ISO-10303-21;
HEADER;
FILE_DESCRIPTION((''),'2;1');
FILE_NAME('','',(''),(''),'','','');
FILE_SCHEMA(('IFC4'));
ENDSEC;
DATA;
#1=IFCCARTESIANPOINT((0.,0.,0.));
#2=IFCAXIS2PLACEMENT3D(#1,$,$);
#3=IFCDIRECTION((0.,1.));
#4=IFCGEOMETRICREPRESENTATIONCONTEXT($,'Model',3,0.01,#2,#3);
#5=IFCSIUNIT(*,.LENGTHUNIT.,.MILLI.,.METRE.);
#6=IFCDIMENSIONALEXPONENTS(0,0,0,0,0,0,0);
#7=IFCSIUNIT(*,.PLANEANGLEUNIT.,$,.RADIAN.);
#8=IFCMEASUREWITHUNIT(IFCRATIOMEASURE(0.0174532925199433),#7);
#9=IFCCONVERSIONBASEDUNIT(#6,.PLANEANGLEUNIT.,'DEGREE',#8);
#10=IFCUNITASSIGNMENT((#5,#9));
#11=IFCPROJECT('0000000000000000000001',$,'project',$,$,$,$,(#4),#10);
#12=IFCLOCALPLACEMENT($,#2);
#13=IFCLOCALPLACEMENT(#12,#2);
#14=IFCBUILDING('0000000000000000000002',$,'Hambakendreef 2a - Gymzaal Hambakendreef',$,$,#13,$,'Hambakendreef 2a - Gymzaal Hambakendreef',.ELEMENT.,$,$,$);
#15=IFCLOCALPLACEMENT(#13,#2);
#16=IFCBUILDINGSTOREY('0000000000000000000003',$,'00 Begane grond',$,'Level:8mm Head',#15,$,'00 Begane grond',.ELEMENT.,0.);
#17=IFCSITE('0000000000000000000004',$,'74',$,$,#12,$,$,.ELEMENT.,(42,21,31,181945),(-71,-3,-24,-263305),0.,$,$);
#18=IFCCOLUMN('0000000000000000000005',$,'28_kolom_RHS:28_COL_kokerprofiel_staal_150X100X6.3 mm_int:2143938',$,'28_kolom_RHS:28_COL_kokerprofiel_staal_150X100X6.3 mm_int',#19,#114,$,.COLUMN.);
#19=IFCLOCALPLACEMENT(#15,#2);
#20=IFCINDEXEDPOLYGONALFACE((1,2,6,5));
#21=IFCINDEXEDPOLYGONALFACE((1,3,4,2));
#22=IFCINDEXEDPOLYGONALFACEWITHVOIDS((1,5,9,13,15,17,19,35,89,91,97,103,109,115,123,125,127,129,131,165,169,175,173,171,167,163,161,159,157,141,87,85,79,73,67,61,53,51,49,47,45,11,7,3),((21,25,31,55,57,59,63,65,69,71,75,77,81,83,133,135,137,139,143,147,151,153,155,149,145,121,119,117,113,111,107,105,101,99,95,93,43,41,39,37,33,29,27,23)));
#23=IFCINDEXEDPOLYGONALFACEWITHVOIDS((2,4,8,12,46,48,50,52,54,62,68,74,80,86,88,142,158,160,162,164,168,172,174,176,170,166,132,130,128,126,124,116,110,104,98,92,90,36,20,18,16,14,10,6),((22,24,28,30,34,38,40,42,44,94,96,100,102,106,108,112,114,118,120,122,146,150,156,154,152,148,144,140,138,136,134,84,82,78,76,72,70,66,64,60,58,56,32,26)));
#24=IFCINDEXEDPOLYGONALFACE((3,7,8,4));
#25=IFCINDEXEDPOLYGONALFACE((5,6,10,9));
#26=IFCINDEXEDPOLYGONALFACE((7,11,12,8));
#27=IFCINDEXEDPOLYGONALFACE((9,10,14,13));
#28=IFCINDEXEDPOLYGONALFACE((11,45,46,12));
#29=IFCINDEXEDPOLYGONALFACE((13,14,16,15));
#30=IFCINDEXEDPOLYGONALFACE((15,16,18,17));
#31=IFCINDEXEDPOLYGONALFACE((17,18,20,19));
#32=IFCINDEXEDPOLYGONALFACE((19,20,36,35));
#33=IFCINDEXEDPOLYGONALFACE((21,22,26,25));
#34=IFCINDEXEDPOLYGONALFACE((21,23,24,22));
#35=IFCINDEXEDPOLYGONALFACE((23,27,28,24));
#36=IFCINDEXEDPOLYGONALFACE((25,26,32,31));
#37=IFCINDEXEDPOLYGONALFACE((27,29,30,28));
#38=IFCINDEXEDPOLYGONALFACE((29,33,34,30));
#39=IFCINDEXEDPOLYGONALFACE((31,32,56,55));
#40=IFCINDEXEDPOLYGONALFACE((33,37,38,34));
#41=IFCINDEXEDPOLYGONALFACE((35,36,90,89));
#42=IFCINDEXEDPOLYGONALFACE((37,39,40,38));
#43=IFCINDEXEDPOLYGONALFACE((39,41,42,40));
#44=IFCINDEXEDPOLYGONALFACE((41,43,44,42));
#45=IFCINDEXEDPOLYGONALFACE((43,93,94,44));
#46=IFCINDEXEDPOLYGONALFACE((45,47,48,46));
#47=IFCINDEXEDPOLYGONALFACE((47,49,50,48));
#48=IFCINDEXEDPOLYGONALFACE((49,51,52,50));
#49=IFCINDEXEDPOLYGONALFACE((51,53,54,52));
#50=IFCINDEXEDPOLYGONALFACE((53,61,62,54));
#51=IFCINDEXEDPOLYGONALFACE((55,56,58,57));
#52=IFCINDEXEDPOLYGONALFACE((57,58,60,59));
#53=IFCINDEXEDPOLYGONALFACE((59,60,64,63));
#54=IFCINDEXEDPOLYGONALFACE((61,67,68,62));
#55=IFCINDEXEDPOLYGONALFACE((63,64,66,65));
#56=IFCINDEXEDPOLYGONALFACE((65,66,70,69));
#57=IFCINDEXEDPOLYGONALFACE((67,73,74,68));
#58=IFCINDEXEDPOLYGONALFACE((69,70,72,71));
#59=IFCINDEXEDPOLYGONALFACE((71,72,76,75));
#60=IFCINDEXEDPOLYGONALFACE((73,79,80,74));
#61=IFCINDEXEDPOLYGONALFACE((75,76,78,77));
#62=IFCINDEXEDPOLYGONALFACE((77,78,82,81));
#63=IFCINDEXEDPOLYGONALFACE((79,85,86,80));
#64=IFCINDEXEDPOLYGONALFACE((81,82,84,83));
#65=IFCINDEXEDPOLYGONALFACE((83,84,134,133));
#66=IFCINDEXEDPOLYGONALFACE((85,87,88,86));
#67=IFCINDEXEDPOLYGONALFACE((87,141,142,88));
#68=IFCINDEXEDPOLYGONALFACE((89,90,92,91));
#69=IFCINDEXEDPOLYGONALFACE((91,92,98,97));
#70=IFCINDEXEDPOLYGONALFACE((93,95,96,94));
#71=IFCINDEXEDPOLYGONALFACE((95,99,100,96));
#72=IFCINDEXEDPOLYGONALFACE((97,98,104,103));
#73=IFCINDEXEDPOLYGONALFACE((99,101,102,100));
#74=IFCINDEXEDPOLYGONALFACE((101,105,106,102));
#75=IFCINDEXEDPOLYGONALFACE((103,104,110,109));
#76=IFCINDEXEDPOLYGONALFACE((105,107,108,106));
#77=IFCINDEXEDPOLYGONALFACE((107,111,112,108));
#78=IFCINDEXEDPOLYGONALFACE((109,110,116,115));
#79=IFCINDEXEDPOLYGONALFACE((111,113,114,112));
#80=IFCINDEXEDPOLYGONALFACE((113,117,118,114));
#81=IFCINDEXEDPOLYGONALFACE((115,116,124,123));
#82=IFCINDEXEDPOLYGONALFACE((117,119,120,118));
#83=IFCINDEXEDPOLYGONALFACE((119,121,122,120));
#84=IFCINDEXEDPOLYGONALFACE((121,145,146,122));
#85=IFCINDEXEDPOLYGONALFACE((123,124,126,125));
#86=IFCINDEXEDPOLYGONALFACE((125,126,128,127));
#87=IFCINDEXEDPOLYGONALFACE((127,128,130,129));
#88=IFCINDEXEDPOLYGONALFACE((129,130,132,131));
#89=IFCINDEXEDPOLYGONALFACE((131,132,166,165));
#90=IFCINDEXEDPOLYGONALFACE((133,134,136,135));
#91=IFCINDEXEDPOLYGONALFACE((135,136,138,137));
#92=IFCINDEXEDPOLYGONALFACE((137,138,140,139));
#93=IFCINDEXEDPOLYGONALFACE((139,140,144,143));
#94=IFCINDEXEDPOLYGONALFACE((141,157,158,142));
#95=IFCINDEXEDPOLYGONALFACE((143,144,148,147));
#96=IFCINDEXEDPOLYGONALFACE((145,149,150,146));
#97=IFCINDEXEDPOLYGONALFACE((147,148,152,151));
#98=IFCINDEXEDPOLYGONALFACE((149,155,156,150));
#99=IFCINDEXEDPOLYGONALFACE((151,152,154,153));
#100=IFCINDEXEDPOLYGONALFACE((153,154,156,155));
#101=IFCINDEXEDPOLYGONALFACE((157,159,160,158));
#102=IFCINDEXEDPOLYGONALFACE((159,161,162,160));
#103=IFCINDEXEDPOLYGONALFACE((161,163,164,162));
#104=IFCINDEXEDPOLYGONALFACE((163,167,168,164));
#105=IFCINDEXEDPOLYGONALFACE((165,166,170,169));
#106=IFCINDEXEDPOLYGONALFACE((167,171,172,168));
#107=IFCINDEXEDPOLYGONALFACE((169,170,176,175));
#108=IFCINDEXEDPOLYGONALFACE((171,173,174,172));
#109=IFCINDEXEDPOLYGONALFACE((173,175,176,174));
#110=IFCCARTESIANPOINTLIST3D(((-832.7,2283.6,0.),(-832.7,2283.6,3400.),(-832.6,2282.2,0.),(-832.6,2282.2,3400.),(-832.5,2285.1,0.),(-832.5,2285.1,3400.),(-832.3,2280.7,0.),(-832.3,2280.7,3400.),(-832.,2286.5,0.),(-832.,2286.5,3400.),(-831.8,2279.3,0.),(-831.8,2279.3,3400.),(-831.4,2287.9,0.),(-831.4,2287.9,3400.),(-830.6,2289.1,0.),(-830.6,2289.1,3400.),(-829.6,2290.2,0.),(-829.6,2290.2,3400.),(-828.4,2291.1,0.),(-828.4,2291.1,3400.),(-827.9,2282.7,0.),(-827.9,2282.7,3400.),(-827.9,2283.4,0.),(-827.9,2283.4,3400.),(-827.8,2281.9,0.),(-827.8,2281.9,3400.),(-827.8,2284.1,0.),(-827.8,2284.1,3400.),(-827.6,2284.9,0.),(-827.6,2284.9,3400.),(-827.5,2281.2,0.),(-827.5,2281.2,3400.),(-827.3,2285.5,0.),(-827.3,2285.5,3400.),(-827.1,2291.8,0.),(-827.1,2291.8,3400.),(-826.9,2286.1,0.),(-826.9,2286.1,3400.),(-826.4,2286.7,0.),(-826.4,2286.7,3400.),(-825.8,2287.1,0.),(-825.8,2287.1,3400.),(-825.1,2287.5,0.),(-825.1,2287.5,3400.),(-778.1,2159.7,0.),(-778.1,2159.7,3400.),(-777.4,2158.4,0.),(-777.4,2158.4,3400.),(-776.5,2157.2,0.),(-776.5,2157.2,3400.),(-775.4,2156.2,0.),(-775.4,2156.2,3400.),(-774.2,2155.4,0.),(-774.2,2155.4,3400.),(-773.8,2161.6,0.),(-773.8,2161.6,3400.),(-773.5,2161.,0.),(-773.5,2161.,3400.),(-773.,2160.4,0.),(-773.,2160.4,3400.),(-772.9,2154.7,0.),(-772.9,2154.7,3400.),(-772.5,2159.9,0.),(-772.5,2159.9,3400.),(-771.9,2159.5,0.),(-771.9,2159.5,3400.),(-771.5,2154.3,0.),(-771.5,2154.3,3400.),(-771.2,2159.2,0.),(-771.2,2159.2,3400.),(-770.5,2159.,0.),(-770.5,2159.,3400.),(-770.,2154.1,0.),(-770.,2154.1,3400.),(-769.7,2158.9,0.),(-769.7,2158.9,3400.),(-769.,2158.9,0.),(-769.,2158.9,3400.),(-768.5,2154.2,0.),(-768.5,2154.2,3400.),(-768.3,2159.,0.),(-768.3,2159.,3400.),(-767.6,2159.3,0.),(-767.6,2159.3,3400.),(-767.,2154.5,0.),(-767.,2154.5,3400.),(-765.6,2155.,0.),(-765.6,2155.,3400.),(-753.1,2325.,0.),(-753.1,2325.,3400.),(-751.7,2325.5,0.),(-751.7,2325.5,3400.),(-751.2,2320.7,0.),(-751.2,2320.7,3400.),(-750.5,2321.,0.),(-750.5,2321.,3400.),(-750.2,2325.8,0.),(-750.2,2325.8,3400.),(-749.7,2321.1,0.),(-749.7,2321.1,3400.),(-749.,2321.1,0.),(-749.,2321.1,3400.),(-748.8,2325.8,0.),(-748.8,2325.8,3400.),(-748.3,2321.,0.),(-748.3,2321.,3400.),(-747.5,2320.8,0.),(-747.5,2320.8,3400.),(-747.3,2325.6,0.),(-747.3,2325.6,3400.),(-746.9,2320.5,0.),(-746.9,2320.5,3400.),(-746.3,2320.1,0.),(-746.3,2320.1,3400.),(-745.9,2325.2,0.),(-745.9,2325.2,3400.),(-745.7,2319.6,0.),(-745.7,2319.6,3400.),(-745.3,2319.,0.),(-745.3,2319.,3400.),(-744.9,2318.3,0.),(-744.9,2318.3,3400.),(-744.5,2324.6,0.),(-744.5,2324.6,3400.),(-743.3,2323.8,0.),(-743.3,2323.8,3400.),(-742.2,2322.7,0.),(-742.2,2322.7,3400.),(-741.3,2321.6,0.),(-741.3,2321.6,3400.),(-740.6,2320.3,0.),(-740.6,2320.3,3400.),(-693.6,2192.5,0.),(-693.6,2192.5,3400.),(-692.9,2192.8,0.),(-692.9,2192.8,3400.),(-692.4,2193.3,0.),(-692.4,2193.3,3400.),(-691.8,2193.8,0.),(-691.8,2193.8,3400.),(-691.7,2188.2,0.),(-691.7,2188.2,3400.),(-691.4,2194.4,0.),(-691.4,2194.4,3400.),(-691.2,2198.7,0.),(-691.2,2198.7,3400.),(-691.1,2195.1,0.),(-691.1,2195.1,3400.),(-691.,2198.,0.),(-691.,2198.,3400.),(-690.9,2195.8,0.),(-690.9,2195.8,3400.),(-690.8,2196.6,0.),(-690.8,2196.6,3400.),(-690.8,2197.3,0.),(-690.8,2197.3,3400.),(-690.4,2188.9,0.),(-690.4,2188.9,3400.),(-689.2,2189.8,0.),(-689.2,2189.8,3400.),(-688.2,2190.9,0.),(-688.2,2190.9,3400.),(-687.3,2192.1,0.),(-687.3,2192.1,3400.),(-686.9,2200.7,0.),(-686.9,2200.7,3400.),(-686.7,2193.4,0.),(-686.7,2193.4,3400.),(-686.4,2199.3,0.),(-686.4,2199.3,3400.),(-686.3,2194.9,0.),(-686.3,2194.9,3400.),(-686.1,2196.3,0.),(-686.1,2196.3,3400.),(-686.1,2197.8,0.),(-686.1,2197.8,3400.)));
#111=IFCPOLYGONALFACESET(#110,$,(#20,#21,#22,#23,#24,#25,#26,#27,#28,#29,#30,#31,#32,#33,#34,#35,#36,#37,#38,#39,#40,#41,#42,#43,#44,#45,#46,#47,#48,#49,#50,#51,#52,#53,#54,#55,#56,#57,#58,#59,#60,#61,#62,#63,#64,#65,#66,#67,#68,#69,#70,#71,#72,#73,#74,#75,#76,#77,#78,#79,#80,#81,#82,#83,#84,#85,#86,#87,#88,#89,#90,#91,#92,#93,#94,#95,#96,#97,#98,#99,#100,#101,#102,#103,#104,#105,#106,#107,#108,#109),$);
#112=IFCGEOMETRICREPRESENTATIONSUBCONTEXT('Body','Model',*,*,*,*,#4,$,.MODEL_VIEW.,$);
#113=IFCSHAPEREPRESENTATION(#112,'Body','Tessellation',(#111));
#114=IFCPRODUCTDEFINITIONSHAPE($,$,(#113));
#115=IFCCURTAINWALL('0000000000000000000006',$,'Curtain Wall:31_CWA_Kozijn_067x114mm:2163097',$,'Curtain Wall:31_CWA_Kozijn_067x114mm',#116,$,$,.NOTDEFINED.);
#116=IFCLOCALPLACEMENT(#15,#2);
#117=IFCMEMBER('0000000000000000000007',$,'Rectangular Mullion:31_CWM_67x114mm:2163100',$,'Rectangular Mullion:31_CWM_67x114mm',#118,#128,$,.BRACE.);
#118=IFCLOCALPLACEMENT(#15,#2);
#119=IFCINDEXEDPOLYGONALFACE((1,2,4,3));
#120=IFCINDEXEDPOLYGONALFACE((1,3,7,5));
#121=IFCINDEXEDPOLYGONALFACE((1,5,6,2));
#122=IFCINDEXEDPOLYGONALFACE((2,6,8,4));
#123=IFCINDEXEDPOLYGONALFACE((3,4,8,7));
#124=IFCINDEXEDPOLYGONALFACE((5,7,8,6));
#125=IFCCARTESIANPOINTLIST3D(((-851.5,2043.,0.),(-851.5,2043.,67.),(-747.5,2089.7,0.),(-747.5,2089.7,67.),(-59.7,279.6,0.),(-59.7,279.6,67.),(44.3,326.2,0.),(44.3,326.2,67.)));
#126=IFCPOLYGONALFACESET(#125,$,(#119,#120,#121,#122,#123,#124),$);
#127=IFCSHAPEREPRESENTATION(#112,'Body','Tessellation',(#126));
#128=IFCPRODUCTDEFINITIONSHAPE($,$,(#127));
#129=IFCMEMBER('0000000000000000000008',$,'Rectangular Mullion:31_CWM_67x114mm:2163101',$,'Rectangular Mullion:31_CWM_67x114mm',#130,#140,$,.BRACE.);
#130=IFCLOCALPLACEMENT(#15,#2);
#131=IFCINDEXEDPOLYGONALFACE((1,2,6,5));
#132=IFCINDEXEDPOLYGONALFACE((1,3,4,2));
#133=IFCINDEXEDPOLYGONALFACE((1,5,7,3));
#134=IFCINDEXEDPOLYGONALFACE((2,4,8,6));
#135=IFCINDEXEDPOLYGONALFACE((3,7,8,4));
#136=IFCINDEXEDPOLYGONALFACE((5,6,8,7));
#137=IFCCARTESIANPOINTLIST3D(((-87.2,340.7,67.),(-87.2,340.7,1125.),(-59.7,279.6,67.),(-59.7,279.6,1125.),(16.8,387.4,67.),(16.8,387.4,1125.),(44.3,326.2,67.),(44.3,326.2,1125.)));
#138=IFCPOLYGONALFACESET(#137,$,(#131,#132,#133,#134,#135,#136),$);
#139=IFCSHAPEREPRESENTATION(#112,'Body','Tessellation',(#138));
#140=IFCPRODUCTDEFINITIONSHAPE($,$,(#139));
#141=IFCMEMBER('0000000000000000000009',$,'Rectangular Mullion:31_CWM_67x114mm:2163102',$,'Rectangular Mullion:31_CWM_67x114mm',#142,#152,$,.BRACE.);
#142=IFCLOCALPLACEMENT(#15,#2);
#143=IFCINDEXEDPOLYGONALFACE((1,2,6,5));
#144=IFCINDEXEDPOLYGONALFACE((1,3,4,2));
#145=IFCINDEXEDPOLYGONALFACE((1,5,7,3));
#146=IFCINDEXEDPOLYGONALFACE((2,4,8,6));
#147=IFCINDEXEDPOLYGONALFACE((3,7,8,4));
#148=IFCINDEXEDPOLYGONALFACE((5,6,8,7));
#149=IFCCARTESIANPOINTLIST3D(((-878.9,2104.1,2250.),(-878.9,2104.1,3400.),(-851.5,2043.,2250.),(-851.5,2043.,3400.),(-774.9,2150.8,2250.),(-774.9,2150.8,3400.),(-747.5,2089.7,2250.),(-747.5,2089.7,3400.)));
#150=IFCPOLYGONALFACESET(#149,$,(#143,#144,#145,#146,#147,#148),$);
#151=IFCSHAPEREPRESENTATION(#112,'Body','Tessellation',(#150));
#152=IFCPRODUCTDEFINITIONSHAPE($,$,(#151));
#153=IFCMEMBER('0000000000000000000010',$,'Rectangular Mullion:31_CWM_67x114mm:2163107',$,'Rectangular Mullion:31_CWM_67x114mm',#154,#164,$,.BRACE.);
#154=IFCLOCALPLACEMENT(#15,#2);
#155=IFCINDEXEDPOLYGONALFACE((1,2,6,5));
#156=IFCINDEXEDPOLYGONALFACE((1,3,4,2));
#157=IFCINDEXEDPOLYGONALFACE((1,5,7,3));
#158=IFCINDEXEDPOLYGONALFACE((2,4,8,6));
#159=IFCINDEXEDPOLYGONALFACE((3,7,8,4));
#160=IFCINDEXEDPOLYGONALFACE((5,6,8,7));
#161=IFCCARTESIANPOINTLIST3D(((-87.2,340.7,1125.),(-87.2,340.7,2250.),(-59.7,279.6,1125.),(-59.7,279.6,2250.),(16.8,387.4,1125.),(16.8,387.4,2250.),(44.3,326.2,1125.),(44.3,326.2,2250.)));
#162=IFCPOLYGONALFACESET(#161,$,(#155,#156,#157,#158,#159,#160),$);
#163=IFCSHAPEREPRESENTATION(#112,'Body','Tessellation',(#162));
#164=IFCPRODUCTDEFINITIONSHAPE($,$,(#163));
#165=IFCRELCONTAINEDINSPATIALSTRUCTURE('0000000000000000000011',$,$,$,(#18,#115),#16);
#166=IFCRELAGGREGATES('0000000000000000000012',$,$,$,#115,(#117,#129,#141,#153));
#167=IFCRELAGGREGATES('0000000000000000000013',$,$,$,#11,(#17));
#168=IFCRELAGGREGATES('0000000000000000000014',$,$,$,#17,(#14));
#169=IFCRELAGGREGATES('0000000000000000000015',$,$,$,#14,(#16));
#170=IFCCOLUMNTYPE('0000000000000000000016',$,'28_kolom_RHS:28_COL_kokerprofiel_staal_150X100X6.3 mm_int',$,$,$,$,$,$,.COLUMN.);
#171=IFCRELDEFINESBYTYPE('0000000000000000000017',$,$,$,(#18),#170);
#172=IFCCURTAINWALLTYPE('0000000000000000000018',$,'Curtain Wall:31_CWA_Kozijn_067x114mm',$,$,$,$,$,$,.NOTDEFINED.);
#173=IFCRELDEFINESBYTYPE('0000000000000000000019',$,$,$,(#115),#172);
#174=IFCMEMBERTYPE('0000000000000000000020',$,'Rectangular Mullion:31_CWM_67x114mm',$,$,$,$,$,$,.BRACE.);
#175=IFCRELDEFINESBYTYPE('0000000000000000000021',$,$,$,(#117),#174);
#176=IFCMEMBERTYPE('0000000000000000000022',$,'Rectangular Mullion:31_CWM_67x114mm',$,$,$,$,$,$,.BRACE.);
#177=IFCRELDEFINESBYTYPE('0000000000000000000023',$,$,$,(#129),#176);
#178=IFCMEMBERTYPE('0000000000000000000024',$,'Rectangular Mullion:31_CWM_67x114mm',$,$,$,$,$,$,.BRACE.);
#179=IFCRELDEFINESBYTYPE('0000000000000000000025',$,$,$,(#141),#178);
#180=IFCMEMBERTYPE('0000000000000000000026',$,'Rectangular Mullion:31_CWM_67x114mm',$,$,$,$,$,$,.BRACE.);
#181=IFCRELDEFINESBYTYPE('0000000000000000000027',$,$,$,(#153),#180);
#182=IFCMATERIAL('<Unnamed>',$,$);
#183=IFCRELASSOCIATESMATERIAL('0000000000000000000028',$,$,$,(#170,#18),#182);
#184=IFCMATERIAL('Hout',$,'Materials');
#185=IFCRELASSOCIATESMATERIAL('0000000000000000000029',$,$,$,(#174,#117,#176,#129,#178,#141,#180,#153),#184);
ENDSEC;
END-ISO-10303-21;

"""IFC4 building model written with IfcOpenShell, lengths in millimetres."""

from ifc_helpers import new_model, entity, si_unit, converted_unit, direction, frame, origin, place, context, subcontext, project, spatial, indexed_curve, outline, extrude, source, transform, mapped, material, type_object, type_shapes, element, aggregate, save


model = new_model("IFC4")

# Units and contexts
model_context = context("Model", 3, precision=0.01, world=origin(), true_north=direction((0.0, 1.0)))
body_context = subcontext(model_context, "Body", "Model", "MODEL_VIEW")
ifc_project = project(units=[si_unit("LENGTHUNIT", "METRE", prefix="MILLI"), converted_unit("PLANEANGLEUNIT", "DEGREE", entity("IfcRatioMeasure", 0.0174532925199433), si_unit("PLANEANGLEUNIT", "RADIAN"), dimensions=[0, 0, 0, 0, 0, 0, 0])], contexts=[model_context])

# Site, building, storey
site_placement = place(None, origin())
site = spatial("IfcSite", under=ifc_project, at=site_placement, Name="74", CompositionType="ELEMENT", RefLatitude=(42, 21, 31, 181945), RefLongitude=(-71, -3, -24, -263305), RefElevation=0.0)
building_placement = place(site_placement, origin())
building = spatial("IfcBuilding", under=site, at=building_placement, Name="Hambakendreef 2a - Gymzaal Hambakendreef", LongName="Hambakendreef 2a - Gymzaal Hambakendreef", CompositionType="ELEMENT")
storey_placement = place(building_placement, origin())
storey = spatial("IfcBuildingStorey", under=building, at=storey_placement, Name="00 Begane grond", ObjectType="Level:8mm Head", LongName="00 Begane grond", CompositionType="ELEMENT", Elevation=0.0)

# Column
ifc_material_1 = material(Name="<Unnamed>")
column_type = type_object("IfcColumnType", Name="28_kolom_RHS:28_COL_kokerprofiel_staal_150X100X6.3 mm_int", PredefinedType="COLUMN", material=ifc_material_1)
shared_shape_1 = source(origin(), body_context, "Body", "SweptSolid", [
    extrude(outline(indexed_curve([(-40.5, -75.0), (40.5, -75.0), (42.0, -74.9), (43.5, -74.5), (44.8, -74.0), (46.1, -73.2), (47.2, -72.2), (48.2, -71.1), (49.0, -69.8), (49.5, -68.5), (49.9, -67.0), (50.0, -65.6), (50.0, 65.6), (49.9, 67.0), (49.5, 68.5), (49.0, 69.8), (48.2, 71.1), (47.2, 72.2), (46.1, 73.2), (44.8, 74.0), (43.5, 74.5), (42.0, 74.9), (40.5, 75.0), (-40.5, 75.0), (-42.0, 74.9), (-43.5, 74.5), (-44.8, 74.0), (-46.1, 73.2), (-47.2, 72.2), (-48.2, 71.1), (-49.0, 69.8), (-49.5, 68.5), (-49.9, 67.0), (-50.0, 65.6), (-50.0, -65.6), (-49.9, -67.0), (-49.5, -68.5), (-49.0, -69.8), (-48.2, -71.1), (-47.2, -72.2), (-46.1, -73.2), (-44.8, -74.0), (-43.5, -74.5), (-42.0, -74.9), (-40.5, -75.0)], self_intersect=False), holes=[indexed_curve([(-45.3, 65.5), (-45.2, 66.3), (-45.0, 67.0), (-44.8, 67.7), (-44.4, 68.3), (-43.9, 68.9), (-43.3, 69.4), (-42.7, 69.8), (-42.0, 70.0), (-41.3, 70.2), (-40.6, 70.3), (40.5, 70.3), (41.3, 70.2), (42.0, 70.0), (42.7, 69.8), (43.3, 69.4), (43.9, 68.9), (44.4, 68.3), (44.8, 67.7), (45.0, 67.0), (45.2, 66.3), (45.3, 65.5), (45.3, -65.5), (45.2, -66.3), (45.0, -67.0), (44.8, -67.7), (44.4, -68.3), (43.9, -68.9), (43.3, -69.4), (42.7, -69.8), (42.0, -70.0), (41.3, -70.2), (40.5, -70.3), (-40.6, -70.3), (-41.3, -70.2), (-42.0, -70.0), (-42.7, -69.8), (-43.3, -69.4), (-43.9, -68.9), (-44.4, -68.3), (-44.8, -67.7), (-45.0, -67.0), (-45.2, -66.3), (-45.3, -65.5), (-45.3, 65.5)], self_intersect=False)]), frame((235.6, 34.3, 0.0), z_axis=(0.0, 0.0, 1.0), x_axis=(0.0, 1.0, 0.0)), (0.0, 0.0, 1.0), 3400.0),
])
type_shapes(column_type, [shared_shape_1])
for number, where, z_axis, x_axis, name in (
    (1, (-887.1, 2440.9, 0.0), (0.0, 0.0, 1.0), (0.40959, -0.91227, 0.0), "28_kolom_RHS:28_COL_kokerprofiel_staal_150X100X6.3 mm_int:2143938"),
):
    element("IfcColumn", number, at=place(storey_placement, frame(where, z_axis=z_axis, x_axis=x_axis)), inside=storey, type_object=column_type, material=ifc_material_1, Name=name, ObjectType="28_kolom_RHS:28_COL_kokerprofiel_staal_150X100X6.3 mm_int", PredefinedType="COLUMN", context=body_context, shape_type="MappedRepresentation", body=[
        mapped(shared_shape_1, transform((0.0, 0.0, 0.0), scale=1.0)),
    ])

# Curtain wall, members
curtain_wall_type = type_object("IfcCurtainWallType", Name="Curtain Wall:31_CWA_Kozijn_067x114mm", PredefinedType="NOTDEFINED")
curtain_wall_placement = place(storey_placement, origin())
curtain_wall = element("IfcCurtainWall", 2, at=curtain_wall_placement, inside=storey, type_object=curtain_wall_type, Name="Curtain Wall:31_CWA_Kozijn_067x114mm:2163097", ObjectType="Curtain Wall:31_CWA_Kozijn_067x114mm", PredefinedType="NOTDEFINED")
ifc_material_2 = material(Name="Hout", Category="Materials")
member_type_1 = type_object("IfcMemberType", Name="Rectangular Mullion:31_CWM_67x114mm", PredefinedType="BRACE", material=ifc_material_2)
shared_shape_2 = source(origin(), body_context, "Body", "SweptSolid", [
    extrude(outline(indexed_curve([(-57.0, -33.5), (57.0, -33.5), (57.0, 33.5), (-57.0, 33.5), (-57.0, -33.5)], self_intersect=False)), frame((-33.5, 0.0, -1933.0), z_axis=(0.0, 0.0, 1.0), x_axis=(0.0, -1.0, 0.0)), (0.0, 0.0, 1.0), 1933.0),
])
type_shapes(member_type_1, [shared_shape_2])
member_1_placement = place(storey_placement, frame((-799.5, 2066.3, 0.0), z_axis=(-0.40959, 0.91227, 0.0), x_axis=(0.0, 0.0, -1.0)))
member_1 = element("IfcMember", 3, at=member_1_placement, type_object=member_type_1, material=ifc_material_2, Name="Rectangular Mullion:31_CWM_67x114mm:2163100", ObjectType="Rectangular Mullion:31_CWM_67x114mm", PredefinedType="BRACE", context=body_context, shape_type="MappedRepresentation", body=[
    mapped(shared_shape_2, transform((0.0, 0.0, 0.0), scale=1.0)),
])
member_type_2 = type_object("IfcMemberType", Name="Rectangular Mullion:31_CWM_67x114mm", PredefinedType="BRACE", material=ifc_material_2)
shared_shape_3 = source(origin(), body_context, "Body", "SweptSolid", [
    extrude(outline(indexed_curve([(-57.0, -33.5), (57.0, -33.5), (57.0, 33.5), (-57.0, 33.5), (-57.0, -33.5)], self_intersect=False)), frame((-33.5, 0.0, -1058.0), z_axis=(0.0, 0.0, 1.0), x_axis=(0.0, -1.0, 0.0)), (0.0, 0.0, 1.0), 1058.0),
])
type_shapes(member_type_2, [shared_shape_3])
member_2_placement = place(storey_placement, frame((-7.7, 302.9, 67.0), z_axis=(0.0, 0.0, -1.0), x_axis=(0.40959, -0.91227, 0.0)))
member_2 = element("IfcMember", 4, at=member_2_placement, type_object=member_type_2, material=ifc_material_2, Name="Rectangular Mullion:31_CWM_67x114mm:2163101", ObjectType="Rectangular Mullion:31_CWM_67x114mm", PredefinedType="BRACE", context=body_context, shape_type="MappedRepresentation", body=[
    mapped(shared_shape_3, transform((0.0, 0.0, 0.0), scale=1.0)),
])
member_type_3 = type_object("IfcMemberType", Name="Rectangular Mullion:31_CWM_67x114mm", PredefinedType="BRACE", material=ifc_material_2)
shared_shape_4 = source(origin(), body_context, "Body", "SweptSolid", [
    extrude(outline(indexed_curve([(-57.0, -33.5), (57.0, -33.5), (57.0, 33.5), (-57.0, 33.5), (-57.0, -33.5)], self_intersect=False)), frame((-33.5, 0.0, -1150.0), z_axis=(0.0, 0.0, 1.0), x_axis=(0.0, -1.0, 0.0)), (0.0, 0.0, 1.0), 1150.0),
])
type_shapes(member_type_3, [shared_shape_4])
member_3_placement = place(storey_placement, frame((-826.9, 2127.4, 3400.0), z_axis=(0.0, 0.0, 1.0), x_axis=(-0.40959, 0.91227, 0.0)))
member_3 = element("IfcMember", 5, at=member_3_placement, type_object=member_type_3, material=ifc_material_2, Name="Rectangular Mullion:31_CWM_67x114mm:2163102", ObjectType="Rectangular Mullion:31_CWM_67x114mm", PredefinedType="BRACE", context=body_context, shape_type="MappedRepresentation", body=[
    mapped(shared_shape_4, transform((0.0, 0.0, 0.0), scale=1.0)),
])
member_type_4 = type_object("IfcMemberType", Name="Rectangular Mullion:31_CWM_67x114mm", PredefinedType="BRACE", material=ifc_material_2)
shared_shape_5 = source(origin(), body_context, "Body", "SweptSolid", [
    extrude(outline(indexed_curve([(-57.0, -33.5), (57.0, -33.5), (57.0, 33.5), (-57.0, 33.5), (-57.0, -33.5)], self_intersect=False)), frame((-33.5, 0.0, -1125.0), z_axis=(0.0, 0.0, 1.0), x_axis=(0.0, -1.0, 0.0)), (0.0, 0.0, 1.0), 1125.0),
])
type_shapes(member_type_4, [shared_shape_5])
member_4_placement = place(storey_placement, frame((-7.7, 302.9, 1125.0), z_axis=(0.0, 0.0, -1.0), x_axis=(0.40959, -0.91227, 0.0)))
member_4 = element("IfcMember", 6, at=member_4_placement, type_object=member_type_4, material=ifc_material_2, Name="Rectangular Mullion:31_CWM_67x114mm:2163107", ObjectType="Rectangular Mullion:31_CWM_67x114mm", PredefinedType="BRACE", context=body_context, shape_type="MappedRepresentation", body=[
    mapped(shared_shape_5, transform((0.0, 0.0, 0.0), scale=1.0)),
])
aggregate(curtain_wall, [member_1, member_2, member_3, member_4])

save(model, "model.ifc")
